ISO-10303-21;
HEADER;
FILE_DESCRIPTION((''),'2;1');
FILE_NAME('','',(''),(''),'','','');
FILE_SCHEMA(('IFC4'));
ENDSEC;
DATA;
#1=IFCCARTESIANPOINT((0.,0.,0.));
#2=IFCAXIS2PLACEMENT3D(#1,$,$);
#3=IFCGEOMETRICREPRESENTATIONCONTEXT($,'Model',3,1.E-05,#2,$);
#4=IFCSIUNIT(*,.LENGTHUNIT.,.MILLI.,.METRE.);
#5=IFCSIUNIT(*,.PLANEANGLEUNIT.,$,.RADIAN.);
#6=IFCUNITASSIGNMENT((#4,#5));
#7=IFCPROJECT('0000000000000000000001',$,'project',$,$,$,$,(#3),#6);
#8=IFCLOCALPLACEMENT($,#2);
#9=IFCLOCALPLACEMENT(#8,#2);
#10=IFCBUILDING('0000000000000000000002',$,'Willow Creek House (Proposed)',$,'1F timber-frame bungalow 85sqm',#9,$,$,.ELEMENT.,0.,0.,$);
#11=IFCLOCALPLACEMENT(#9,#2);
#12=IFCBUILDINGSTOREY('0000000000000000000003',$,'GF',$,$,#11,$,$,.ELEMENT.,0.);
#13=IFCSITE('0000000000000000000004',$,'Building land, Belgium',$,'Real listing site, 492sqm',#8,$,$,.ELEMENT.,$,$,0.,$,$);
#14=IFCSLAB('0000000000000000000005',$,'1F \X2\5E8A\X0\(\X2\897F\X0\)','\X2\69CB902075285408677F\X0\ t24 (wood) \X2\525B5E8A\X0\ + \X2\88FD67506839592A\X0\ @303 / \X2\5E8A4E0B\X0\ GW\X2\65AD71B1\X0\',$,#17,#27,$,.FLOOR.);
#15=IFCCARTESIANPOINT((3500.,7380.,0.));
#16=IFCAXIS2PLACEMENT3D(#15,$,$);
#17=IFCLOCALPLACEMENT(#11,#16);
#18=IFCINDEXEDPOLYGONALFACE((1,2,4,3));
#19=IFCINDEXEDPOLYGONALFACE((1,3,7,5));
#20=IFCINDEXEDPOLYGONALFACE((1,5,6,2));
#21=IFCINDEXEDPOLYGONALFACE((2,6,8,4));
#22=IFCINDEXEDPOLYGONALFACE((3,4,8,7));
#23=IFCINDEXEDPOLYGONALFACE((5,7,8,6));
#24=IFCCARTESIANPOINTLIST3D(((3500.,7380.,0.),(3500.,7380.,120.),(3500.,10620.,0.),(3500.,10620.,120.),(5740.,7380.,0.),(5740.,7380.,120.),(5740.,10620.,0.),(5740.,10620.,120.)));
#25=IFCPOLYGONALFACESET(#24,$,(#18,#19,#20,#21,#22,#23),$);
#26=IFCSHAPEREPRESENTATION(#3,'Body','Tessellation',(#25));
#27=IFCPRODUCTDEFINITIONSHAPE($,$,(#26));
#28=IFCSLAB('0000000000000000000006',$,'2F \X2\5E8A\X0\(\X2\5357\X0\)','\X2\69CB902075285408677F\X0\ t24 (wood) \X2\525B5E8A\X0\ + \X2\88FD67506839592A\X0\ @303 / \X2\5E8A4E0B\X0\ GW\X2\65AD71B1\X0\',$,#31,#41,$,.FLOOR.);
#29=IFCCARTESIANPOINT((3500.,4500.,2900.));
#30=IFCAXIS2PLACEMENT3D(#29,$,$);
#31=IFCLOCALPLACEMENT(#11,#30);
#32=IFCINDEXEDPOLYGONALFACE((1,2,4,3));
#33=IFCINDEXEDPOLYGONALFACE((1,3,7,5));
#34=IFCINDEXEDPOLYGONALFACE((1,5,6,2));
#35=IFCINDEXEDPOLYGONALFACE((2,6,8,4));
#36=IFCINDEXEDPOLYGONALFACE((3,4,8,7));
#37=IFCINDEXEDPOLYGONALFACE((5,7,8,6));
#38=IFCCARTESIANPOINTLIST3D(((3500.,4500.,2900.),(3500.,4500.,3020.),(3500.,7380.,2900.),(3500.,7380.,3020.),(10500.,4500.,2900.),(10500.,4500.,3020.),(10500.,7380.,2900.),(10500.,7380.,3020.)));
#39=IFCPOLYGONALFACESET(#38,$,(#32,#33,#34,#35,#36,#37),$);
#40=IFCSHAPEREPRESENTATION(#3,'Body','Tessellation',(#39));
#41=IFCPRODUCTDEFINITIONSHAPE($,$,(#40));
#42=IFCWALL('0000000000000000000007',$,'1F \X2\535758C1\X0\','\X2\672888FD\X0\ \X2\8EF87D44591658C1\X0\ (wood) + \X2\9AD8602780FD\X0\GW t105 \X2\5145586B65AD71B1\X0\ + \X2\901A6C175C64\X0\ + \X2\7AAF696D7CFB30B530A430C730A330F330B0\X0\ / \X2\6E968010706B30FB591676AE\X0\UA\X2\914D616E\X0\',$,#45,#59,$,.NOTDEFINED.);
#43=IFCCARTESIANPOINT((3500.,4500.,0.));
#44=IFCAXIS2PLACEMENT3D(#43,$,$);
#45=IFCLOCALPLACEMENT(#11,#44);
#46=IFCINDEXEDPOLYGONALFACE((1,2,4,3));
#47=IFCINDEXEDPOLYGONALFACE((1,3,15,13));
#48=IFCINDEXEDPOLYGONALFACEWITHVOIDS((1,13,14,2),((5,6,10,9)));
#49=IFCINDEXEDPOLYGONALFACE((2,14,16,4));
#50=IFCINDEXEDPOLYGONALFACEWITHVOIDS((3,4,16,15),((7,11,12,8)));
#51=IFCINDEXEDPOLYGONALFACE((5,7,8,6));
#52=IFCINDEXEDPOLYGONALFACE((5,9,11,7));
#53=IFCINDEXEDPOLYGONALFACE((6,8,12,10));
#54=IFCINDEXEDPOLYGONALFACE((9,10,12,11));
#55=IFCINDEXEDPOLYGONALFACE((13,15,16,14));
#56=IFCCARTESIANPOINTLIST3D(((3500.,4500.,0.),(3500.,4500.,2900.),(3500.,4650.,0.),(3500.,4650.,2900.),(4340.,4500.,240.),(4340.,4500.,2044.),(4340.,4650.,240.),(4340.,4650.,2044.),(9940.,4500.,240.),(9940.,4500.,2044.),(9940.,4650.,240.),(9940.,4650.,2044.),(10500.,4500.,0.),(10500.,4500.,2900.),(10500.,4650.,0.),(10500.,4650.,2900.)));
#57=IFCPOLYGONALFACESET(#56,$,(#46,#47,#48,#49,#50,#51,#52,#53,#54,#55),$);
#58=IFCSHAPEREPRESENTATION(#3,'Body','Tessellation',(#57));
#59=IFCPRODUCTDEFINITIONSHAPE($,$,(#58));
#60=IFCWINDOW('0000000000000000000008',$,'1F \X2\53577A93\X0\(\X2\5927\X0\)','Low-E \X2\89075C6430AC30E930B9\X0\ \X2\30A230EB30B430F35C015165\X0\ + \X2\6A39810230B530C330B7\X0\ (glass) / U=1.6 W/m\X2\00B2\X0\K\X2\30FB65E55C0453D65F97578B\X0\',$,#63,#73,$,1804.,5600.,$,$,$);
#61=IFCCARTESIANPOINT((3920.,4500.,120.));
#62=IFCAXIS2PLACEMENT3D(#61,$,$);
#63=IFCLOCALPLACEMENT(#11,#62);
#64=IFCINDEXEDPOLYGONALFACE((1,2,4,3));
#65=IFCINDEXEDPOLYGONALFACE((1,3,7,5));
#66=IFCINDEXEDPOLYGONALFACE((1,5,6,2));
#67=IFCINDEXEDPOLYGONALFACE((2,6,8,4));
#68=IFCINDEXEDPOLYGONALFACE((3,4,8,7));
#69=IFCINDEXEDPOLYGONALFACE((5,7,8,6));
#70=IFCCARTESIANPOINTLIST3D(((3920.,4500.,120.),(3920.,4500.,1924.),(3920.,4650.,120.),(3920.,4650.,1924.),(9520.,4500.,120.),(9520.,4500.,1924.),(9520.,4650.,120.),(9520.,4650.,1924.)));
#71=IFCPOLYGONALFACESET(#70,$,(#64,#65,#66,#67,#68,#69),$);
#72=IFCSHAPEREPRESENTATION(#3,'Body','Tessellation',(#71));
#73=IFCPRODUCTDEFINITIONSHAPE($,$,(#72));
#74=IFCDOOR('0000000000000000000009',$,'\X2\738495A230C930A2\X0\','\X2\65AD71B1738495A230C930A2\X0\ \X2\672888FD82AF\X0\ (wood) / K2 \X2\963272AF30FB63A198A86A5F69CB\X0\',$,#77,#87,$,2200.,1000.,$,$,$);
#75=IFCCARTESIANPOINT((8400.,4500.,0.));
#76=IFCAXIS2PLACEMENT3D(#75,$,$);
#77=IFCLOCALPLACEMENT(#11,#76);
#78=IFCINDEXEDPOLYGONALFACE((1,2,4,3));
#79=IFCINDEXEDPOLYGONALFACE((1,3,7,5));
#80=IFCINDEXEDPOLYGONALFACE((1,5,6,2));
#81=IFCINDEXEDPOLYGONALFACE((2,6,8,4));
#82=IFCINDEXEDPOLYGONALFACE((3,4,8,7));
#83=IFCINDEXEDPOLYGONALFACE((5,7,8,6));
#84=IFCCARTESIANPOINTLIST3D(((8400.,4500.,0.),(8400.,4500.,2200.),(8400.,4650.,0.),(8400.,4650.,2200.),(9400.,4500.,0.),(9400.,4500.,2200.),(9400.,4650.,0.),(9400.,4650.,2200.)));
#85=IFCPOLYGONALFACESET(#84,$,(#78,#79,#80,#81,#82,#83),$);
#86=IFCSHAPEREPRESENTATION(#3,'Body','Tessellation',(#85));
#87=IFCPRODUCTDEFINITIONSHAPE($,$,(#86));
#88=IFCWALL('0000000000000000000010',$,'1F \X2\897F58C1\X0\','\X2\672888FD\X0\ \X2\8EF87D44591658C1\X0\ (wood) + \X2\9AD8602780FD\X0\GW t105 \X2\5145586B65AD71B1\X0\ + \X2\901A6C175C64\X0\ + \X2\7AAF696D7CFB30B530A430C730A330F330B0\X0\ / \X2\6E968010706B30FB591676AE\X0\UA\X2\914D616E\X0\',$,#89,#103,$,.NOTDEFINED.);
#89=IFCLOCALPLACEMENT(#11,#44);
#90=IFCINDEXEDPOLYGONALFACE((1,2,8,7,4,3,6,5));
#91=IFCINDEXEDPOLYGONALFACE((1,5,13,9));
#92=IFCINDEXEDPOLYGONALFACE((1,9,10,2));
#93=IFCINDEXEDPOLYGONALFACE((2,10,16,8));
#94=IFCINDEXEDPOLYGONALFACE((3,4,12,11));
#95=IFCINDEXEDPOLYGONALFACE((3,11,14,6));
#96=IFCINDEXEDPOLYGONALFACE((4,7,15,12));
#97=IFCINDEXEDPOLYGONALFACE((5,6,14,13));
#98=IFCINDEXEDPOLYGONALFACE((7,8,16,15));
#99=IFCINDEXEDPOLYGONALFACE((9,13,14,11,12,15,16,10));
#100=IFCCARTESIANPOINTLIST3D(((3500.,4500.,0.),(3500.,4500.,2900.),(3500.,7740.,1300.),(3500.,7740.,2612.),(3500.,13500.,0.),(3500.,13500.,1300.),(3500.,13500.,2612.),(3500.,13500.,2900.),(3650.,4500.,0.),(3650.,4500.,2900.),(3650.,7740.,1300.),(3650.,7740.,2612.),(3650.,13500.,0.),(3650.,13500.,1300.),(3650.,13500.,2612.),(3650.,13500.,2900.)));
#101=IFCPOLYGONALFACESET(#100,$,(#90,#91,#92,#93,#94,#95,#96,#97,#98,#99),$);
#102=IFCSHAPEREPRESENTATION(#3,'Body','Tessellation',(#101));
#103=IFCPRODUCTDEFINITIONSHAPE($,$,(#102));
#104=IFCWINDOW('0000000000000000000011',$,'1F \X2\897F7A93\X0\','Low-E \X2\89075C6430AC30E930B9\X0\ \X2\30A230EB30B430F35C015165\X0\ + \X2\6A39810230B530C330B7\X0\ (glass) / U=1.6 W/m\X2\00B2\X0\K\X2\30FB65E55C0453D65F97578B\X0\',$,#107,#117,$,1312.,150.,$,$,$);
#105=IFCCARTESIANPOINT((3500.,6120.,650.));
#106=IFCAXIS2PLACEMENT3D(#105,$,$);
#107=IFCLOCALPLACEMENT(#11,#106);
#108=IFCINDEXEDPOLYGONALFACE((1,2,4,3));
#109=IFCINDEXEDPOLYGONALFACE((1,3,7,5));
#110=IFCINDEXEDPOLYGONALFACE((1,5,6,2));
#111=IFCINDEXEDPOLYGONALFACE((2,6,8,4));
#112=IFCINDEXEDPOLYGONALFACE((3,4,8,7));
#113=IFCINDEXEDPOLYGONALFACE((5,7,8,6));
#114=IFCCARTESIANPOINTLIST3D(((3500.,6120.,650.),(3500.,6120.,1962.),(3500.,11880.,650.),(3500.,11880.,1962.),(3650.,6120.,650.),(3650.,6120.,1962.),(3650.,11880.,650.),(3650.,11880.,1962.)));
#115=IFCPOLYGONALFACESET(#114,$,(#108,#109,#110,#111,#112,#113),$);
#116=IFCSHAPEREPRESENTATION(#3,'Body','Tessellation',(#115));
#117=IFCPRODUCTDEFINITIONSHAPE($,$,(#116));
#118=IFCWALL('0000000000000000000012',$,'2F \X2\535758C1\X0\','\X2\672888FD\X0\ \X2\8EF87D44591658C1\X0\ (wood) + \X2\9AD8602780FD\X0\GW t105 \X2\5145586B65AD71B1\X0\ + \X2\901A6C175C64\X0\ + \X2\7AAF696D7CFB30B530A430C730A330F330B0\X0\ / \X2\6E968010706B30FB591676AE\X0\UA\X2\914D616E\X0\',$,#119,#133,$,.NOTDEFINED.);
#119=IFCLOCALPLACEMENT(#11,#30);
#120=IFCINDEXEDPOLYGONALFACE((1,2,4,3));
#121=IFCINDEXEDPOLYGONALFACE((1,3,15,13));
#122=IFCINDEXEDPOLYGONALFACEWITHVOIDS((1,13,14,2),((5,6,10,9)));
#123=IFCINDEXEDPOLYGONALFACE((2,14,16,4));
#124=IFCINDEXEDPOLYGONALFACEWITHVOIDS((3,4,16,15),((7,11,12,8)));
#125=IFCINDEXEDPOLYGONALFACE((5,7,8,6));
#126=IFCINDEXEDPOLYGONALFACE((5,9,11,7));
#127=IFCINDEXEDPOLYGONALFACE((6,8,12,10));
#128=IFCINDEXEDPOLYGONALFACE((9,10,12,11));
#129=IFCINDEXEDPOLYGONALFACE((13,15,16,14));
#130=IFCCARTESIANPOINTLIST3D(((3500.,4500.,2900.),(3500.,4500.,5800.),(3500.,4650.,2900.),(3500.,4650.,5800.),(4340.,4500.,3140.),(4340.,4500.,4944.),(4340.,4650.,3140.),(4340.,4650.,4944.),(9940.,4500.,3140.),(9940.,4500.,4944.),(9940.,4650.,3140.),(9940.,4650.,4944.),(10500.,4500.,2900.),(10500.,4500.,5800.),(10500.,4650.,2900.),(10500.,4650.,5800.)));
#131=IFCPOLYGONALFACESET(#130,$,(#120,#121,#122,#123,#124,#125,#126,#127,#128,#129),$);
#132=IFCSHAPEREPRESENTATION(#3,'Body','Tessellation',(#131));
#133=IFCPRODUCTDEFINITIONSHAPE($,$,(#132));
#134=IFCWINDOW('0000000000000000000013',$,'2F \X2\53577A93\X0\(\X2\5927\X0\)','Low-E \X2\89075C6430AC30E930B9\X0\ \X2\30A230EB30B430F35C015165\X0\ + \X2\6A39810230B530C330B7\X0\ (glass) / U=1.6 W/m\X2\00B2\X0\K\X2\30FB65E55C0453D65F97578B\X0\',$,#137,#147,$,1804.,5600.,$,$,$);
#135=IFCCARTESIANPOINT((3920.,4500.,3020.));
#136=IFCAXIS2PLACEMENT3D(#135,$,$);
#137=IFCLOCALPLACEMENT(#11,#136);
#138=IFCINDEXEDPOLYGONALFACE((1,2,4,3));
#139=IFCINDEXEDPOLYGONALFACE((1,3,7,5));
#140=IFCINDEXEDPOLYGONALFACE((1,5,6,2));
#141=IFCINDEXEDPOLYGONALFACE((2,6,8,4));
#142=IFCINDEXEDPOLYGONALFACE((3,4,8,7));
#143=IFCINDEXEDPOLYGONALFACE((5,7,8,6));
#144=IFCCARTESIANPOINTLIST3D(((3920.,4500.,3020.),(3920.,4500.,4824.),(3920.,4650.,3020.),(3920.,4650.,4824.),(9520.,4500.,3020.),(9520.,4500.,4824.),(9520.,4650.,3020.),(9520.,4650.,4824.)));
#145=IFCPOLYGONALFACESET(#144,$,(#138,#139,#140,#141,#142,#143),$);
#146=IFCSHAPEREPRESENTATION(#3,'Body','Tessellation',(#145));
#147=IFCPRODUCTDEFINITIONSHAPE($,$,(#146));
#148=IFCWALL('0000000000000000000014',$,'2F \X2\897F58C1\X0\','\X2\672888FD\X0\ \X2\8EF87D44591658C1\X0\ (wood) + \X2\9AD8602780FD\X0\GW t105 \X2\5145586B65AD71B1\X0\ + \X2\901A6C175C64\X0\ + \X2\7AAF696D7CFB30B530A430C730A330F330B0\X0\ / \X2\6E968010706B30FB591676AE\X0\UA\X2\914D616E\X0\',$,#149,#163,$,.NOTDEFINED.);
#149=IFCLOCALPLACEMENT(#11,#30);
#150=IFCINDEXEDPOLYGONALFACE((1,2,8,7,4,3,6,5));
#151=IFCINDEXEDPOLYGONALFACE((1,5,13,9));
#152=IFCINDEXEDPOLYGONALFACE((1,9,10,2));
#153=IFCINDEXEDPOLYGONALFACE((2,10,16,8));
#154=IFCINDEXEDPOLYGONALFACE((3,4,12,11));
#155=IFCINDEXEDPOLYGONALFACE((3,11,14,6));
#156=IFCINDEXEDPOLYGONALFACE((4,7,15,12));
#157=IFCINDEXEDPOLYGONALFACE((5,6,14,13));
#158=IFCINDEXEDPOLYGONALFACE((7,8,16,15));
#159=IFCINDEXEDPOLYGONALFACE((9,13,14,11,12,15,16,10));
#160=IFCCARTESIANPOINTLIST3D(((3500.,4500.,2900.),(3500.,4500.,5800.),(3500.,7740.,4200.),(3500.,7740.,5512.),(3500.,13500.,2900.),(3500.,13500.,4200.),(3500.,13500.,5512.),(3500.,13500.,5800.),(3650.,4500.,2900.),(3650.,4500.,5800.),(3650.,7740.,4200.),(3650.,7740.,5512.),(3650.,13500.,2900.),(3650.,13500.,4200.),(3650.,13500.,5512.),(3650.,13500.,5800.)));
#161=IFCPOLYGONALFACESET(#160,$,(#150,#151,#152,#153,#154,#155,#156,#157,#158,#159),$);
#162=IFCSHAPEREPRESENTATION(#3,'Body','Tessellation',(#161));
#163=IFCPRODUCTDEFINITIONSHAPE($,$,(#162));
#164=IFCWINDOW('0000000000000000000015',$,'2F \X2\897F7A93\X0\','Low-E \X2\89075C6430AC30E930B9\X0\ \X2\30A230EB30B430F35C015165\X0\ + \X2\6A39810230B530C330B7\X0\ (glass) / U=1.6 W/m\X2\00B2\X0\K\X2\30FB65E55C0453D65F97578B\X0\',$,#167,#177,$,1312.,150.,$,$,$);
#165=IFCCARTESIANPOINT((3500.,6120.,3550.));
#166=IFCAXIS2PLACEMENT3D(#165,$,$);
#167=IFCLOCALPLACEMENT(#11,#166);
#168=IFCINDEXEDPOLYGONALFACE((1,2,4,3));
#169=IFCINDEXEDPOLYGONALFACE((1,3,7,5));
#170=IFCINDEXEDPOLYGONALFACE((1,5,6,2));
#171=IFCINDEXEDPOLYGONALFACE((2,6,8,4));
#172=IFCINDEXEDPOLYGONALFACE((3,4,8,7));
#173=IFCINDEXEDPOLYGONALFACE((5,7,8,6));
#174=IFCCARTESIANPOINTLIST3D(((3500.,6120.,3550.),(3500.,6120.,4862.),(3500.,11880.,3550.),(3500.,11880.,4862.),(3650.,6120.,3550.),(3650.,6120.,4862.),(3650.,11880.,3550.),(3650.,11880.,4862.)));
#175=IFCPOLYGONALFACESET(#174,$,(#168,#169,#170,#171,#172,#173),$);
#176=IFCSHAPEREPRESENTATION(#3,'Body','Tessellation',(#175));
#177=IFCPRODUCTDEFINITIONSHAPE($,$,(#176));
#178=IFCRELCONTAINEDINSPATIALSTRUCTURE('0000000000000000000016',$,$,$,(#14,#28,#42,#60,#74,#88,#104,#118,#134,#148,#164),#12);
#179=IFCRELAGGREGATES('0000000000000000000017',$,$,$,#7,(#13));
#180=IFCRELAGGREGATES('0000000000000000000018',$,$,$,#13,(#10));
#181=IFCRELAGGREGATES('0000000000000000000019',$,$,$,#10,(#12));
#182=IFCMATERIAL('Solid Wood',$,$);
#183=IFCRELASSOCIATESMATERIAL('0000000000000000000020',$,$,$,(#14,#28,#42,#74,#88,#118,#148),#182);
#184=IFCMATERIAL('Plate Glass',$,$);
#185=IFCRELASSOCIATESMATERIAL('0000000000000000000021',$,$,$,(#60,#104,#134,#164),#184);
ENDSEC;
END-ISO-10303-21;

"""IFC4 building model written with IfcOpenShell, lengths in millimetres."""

from ifc_helpers import new_model, si_unit, frame, frame_2d, origin, place, context, project, spatial, rectangle, extrude, material, element, fill, save


model = new_model("IFC4")

# Units and contexts
model_context = context("Model", 3, precision=1e-05, world=origin())
ifc_project = project(units=[si_unit("LENGTHUNIT", "METRE", prefix="MILLI"), si_unit("PLANEANGLEUNIT", "RADIAN")], contexts=[model_context])

# Site, building, storey
site_placement = place(None, origin())
site = spatial("IfcSite", under=ifc_project, at=site_placement, Name="Building land, Belgium", ObjectType="Real listing site, 492sqm", CompositionType="ELEMENT", RefElevation=0.0)
building_placement = place(site_placement, origin())
building = spatial("IfcBuilding", under=site, at=building_placement, Name="Willow Creek House (Proposed)", ObjectType="1F timber-frame bungalow 85sqm", CompositionType="ELEMENT", ElevationOfRefHeight=0.0, ElevationOfTerrain=0.0)
storey_placement = place(building_placement, origin())
storey = spatial("IfcBuildingStorey", under=building, at=storey_placement, Name="GF", CompositionType="ELEMENT", Elevation=0.0)

# Slabs
ifc_material_1 = material(Name="Solid Wood")
slab_1_placement = place(storey_placement, frame((3500.0, 7380.0, 0.0)))
element("IfcSlab", 1, at=slab_1_placement, inside=storey, material=ifc_material_1, Name="1F 床(西)", Description="構造用合板 t24 (wood) 剛床 + 製材根太 @303 / 床下 GW断熱", PredefinedType="FLOOR", context=model_context, shape_type="SweptSolid", body=[
    extrude(rectangle(XDim=2240.0, YDim=3240.0, at=frame_2d((1120.0, 1620.0))), frame((3500.0, 7380.0, 0.0)), (0.0, 0.0, 1.0), 120.0),
])
slab_2_placement = place(storey_placement, frame((3500.0, 4500.0, 2900.0)))
element("IfcSlab", 2, at=slab_2_placement, inside=storey, material=ifc_material_1, Name="2F 床(南)", Description="構造用合板 t24 (wood) 剛床 + 製材根太 @303 / 床下 GW断熱", PredefinedType="FLOOR", context=model_context, shape_type="SweptSolid", body=[
    extrude(rectangle(XDim=7000.0, YDim=2880.0, at=frame_2d((3500.0, 1440.0))), frame((3500.0, 4500.0, 2900.0)), (0.0, 0.0, 1.0), 120.0),
])

# Wall, openings, window, door
wall_1_placement = place(storey_placement, frame((3500.0, 4500.0, 0.0)))
wall_1 = element("IfcWall", 3, at=wall_1_placement, inside=storey, material=ifc_material_1, Name="1F 南壁", Description="木製 軸組外壁 (wood) + 高性能GW t105 充填断熱 + 通気層 + 窯業系サイディング / 準耐火・外皮UA配慮", PredefinedType="NOTDEFINED", context=model_context, shape_type="SweptSolid", body=[
    extrude(rectangle(XDim=7000.0, YDim=150.0, at=frame_2d((3500.0, 75.0))), frame((3500.0, 4500.0, 0.0)), (0.0, 0.0, 1.0), 2900.0),
])
opening_1_placement = place(storey_placement, frame((3920.0, 4500.0, 120.0)))
opening_1 = element("IfcOpeningElement", 4, at=opening_1_placement, cuts=wall_1, PredefinedType="NOTDEFINED", context=model_context, shape_type="SweptSolid", body=[
    extrude(rectangle(XDim=5600.0, YDim=150.0, at=frame_2d((2800.0, 75.0))), frame((3920.0, 4500.0, 120.0)), (0.0, 0.0, 1.0), 1804.0),
])
opening_2_placement = place(storey_placement, frame((8400.0, 4500.0, 0.0)))
opening_2 = element("IfcOpeningElement", 5, at=opening_2_placement, cuts=wall_1, PredefinedType="NOTDEFINED", context=model_context, shape_type="SweptSolid", body=[
    extrude(rectangle(XDim=1000.0, YDim=150.0, at=frame_2d((500.0, 75.0))), frame((8400.0, 4500.0, 0.0)), (0.0, 0.0, 1.0), 2200.0),
])
ifc_material_2 = material(Name="Plate Glass")
window_1_placement = place(storey_placement, frame((3920.0, 4500.0, 120.0)))
window_1 = element("IfcWindow", 6, at=window_1_placement, inside=storey, material=ifc_material_2, Name="1F 南窓(大)", Description="Low-E 複層ガラス アルゴン封入 + 樹脂サッシ (glass) / U=1.6 W/m²K・日射取得型", OverallHeight=1804.0, OverallWidth=5600.0, context=model_context, shape_type="SweptSolid", body=[
    extrude(rectangle(XDim=5600.0, YDim=150.0, at=frame_2d((2800.0, 75.0))), frame((3920.0, 4500.0, 120.0)), (0.0, 0.0, 1.0), 1804.0),
])
fill(opening_1, window_1)
door_placement = place(storey_placement, frame((8400.0, 4500.0, 0.0)))
door = element("IfcDoor", 7, at=door_placement, inside=storey, material=ifc_material_1, Name="玄関ドア", Description="断熱玄関ドア 木製芯 (wood) / K2 防犯・採風機構", OverallHeight=2200.0, OverallWidth=1000.0, context=model_context, shape_type="SweptSolid", body=[
    extrude(rectangle(XDim=1000.0, YDim=150.0, at=frame_2d((500.0, 75.0))), frame((8400.0, 4500.0, 0.0)), (0.0, 0.0, 1.0), 2200.0),
])
fill(opening_2, door)

# Walls, openings, windows
wall_2_placement = place(storey_placement, frame((3500.0, 4500.0, 0.0)))
wall_2 = element("IfcWall", 8, at=wall_2_placement, inside=storey, material=ifc_material_1, Name="1F 西壁", Description="木製 軸組外壁 (wood) + 高性能GW t105 充填断熱 + 通気層 + 窯業系サイディング / 準耐火・外皮UA配慮", PredefinedType="NOTDEFINED", context=model_context, shape_type="SweptSolid", body=[
    extrude(rectangle(XDim=150.0, YDim=9000.0, at=frame_2d((75.0, 4500.0))), frame((3500.0, 4500.0, 0.0)), (0.0, 0.0, 1.0), 2900.0),
])
opening_3_placement = place(storey_placement, frame((3500.0, 6120.0, 650.0)))
opening_3 = element("IfcOpeningElement", 9, at=opening_3_placement, cuts=wall_2, PredefinedType="NOTDEFINED", context=model_context, shape_type="SweptSolid", body=[
    extrude(rectangle(XDim=150.0, YDim=5760.0, at=frame_2d((75.0, 2880.0))), frame((3500.0, 6120.0, 650.0)), (0.0, 0.0, 1.0), 1312.0),
])
window_2_placement = place(storey_placement, frame((3500.0, 6120.0, 650.0)))
window_2 = element("IfcWindow", 10, at=window_2_placement, inside=storey, material=ifc_material_2, Name="1F 西窓", Description="Low-E 複層ガラス アルゴン封入 + 樹脂サッシ (glass) / U=1.6 W/m²K・日射取得型", OverallHeight=1312.0, OverallWidth=150.0, context=model_context, shape_type="SweptSolid", body=[
    extrude(rectangle(XDim=150.0, YDim=5760.0, at=frame_2d((75.0, 2880.0))), frame((3500.0, 6120.0, 650.0)), (0.0, 0.0, 1.0), 1312.0),
])
fill(opening_3, window_2)
wall_3_placement = place(storey_placement, frame((3500.0, 4500.0, 2900.0)))
wall_3 = element("IfcWall", 11, at=wall_3_placement, inside=storey, material=ifc_material_1, Name="2F 南壁", Description="木製 軸組外壁 (wood) + 高性能GW t105 充填断熱 + 通気層 + 窯業系サイディング / 準耐火・外皮UA配慮", PredefinedType="NOTDEFINED", context=model_context, shape_type="SweptSolid", body=[
    extrude(rectangle(XDim=7000.0, YDim=150.0, at=frame_2d((3500.0, 75.0))), frame((3500.0, 4500.0, 2900.0)), (0.0, 0.0, 1.0), 2900.0),
])
opening_4_placement = place(storey_placement, frame((3920.0, 4500.0, 3020.0)))
opening_4 = element("IfcOpeningElement", 12, at=opening_4_placement, cuts=wall_3, PredefinedType="NOTDEFINED", context=model_context, shape_type="SweptSolid", body=[
    extrude(rectangle(XDim=5600.0, YDim=150.0, at=frame_2d((2800.0, 75.0))), frame((3920.0, 4500.0, 3020.0)), (0.0, 0.0, 1.0), 1804.0),
])
window_3_placement = place(storey_placement, frame((3920.0, 4500.0, 3020.0)))
window_3 = element("IfcWindow", 13, at=window_3_placement, inside=storey, material=ifc_material_2, Name="2F 南窓(大)", Description="Low-E 複層ガラス アルゴン封入 + 樹脂サッシ (glass) / U=1.6 W/m²K・日射取得型", OverallHeight=1804.0, OverallWidth=5600.0, context=model_context, shape_type="SweptSolid", body=[
    extrude(rectangle(XDim=5600.0, YDim=150.0, at=frame_2d((2800.0, 75.0))), frame((3920.0, 4500.0, 3020.0)), (0.0, 0.0, 1.0), 1804.0),
])
fill(opening_4, window_3)
wall_4_placement = place(storey_placement, frame((3500.0, 4500.0, 2900.0)))
wall_4 = element("IfcWall", 14, at=wall_4_placement, inside=storey, material=ifc_material_1, Name="2F 西壁", Description="木製 軸組外壁 (wood) + 高性能GW t105 充填断熱 + 通気層 + 窯業系サイディング / 準耐火・外皮UA配慮", PredefinedType="NOTDEFINED", context=model_context, shape_type="SweptSolid", body=[
    extrude(rectangle(XDim=150.0, YDim=9000.0, at=frame_2d((75.0, 4500.0))), frame((3500.0, 4500.0, 2900.0)), (0.0, 0.0, 1.0), 2900.0),
])
opening_5_placement = place(storey_placement, frame((3500.0, 6120.0, 3550.0)))
opening_5 = element("IfcOpeningElement", 15, at=opening_5_placement, cuts=wall_4, PredefinedType="NOTDEFINED", context=model_context, shape_type="SweptSolid", body=[
    extrude(rectangle(XDim=150.0, YDim=5760.0, at=frame_2d((75.0, 2880.0))), frame((3500.0, 6120.0, 3550.0)), (0.0, 0.0, 1.0), 1312.0),
])
window_4_placement = place(storey_placement, frame((3500.0, 6120.0, 3550.0)))
window_4 = element("IfcWindow", 16, at=window_4_placement, inside=storey, material=ifc_material_2, Name="2F 西窓", Description="Low-E 複層ガラス アルゴン封入 + 樹脂サッシ (glass) / U=1.6 W/m²K・日射取得型", OverallHeight=1312.0, OverallWidth=150.0, context=model_context, shape_type="SweptSolid", body=[
    extrude(rectangle(XDim=150.0, YDim=5760.0, at=frame_2d((75.0, 2880.0))), frame((3500.0, 6120.0, 3550.0)), (0.0, 0.0, 1.0), 1312.0),
])
fill(opening_5, window_4)

save(model, "model.ifc")
